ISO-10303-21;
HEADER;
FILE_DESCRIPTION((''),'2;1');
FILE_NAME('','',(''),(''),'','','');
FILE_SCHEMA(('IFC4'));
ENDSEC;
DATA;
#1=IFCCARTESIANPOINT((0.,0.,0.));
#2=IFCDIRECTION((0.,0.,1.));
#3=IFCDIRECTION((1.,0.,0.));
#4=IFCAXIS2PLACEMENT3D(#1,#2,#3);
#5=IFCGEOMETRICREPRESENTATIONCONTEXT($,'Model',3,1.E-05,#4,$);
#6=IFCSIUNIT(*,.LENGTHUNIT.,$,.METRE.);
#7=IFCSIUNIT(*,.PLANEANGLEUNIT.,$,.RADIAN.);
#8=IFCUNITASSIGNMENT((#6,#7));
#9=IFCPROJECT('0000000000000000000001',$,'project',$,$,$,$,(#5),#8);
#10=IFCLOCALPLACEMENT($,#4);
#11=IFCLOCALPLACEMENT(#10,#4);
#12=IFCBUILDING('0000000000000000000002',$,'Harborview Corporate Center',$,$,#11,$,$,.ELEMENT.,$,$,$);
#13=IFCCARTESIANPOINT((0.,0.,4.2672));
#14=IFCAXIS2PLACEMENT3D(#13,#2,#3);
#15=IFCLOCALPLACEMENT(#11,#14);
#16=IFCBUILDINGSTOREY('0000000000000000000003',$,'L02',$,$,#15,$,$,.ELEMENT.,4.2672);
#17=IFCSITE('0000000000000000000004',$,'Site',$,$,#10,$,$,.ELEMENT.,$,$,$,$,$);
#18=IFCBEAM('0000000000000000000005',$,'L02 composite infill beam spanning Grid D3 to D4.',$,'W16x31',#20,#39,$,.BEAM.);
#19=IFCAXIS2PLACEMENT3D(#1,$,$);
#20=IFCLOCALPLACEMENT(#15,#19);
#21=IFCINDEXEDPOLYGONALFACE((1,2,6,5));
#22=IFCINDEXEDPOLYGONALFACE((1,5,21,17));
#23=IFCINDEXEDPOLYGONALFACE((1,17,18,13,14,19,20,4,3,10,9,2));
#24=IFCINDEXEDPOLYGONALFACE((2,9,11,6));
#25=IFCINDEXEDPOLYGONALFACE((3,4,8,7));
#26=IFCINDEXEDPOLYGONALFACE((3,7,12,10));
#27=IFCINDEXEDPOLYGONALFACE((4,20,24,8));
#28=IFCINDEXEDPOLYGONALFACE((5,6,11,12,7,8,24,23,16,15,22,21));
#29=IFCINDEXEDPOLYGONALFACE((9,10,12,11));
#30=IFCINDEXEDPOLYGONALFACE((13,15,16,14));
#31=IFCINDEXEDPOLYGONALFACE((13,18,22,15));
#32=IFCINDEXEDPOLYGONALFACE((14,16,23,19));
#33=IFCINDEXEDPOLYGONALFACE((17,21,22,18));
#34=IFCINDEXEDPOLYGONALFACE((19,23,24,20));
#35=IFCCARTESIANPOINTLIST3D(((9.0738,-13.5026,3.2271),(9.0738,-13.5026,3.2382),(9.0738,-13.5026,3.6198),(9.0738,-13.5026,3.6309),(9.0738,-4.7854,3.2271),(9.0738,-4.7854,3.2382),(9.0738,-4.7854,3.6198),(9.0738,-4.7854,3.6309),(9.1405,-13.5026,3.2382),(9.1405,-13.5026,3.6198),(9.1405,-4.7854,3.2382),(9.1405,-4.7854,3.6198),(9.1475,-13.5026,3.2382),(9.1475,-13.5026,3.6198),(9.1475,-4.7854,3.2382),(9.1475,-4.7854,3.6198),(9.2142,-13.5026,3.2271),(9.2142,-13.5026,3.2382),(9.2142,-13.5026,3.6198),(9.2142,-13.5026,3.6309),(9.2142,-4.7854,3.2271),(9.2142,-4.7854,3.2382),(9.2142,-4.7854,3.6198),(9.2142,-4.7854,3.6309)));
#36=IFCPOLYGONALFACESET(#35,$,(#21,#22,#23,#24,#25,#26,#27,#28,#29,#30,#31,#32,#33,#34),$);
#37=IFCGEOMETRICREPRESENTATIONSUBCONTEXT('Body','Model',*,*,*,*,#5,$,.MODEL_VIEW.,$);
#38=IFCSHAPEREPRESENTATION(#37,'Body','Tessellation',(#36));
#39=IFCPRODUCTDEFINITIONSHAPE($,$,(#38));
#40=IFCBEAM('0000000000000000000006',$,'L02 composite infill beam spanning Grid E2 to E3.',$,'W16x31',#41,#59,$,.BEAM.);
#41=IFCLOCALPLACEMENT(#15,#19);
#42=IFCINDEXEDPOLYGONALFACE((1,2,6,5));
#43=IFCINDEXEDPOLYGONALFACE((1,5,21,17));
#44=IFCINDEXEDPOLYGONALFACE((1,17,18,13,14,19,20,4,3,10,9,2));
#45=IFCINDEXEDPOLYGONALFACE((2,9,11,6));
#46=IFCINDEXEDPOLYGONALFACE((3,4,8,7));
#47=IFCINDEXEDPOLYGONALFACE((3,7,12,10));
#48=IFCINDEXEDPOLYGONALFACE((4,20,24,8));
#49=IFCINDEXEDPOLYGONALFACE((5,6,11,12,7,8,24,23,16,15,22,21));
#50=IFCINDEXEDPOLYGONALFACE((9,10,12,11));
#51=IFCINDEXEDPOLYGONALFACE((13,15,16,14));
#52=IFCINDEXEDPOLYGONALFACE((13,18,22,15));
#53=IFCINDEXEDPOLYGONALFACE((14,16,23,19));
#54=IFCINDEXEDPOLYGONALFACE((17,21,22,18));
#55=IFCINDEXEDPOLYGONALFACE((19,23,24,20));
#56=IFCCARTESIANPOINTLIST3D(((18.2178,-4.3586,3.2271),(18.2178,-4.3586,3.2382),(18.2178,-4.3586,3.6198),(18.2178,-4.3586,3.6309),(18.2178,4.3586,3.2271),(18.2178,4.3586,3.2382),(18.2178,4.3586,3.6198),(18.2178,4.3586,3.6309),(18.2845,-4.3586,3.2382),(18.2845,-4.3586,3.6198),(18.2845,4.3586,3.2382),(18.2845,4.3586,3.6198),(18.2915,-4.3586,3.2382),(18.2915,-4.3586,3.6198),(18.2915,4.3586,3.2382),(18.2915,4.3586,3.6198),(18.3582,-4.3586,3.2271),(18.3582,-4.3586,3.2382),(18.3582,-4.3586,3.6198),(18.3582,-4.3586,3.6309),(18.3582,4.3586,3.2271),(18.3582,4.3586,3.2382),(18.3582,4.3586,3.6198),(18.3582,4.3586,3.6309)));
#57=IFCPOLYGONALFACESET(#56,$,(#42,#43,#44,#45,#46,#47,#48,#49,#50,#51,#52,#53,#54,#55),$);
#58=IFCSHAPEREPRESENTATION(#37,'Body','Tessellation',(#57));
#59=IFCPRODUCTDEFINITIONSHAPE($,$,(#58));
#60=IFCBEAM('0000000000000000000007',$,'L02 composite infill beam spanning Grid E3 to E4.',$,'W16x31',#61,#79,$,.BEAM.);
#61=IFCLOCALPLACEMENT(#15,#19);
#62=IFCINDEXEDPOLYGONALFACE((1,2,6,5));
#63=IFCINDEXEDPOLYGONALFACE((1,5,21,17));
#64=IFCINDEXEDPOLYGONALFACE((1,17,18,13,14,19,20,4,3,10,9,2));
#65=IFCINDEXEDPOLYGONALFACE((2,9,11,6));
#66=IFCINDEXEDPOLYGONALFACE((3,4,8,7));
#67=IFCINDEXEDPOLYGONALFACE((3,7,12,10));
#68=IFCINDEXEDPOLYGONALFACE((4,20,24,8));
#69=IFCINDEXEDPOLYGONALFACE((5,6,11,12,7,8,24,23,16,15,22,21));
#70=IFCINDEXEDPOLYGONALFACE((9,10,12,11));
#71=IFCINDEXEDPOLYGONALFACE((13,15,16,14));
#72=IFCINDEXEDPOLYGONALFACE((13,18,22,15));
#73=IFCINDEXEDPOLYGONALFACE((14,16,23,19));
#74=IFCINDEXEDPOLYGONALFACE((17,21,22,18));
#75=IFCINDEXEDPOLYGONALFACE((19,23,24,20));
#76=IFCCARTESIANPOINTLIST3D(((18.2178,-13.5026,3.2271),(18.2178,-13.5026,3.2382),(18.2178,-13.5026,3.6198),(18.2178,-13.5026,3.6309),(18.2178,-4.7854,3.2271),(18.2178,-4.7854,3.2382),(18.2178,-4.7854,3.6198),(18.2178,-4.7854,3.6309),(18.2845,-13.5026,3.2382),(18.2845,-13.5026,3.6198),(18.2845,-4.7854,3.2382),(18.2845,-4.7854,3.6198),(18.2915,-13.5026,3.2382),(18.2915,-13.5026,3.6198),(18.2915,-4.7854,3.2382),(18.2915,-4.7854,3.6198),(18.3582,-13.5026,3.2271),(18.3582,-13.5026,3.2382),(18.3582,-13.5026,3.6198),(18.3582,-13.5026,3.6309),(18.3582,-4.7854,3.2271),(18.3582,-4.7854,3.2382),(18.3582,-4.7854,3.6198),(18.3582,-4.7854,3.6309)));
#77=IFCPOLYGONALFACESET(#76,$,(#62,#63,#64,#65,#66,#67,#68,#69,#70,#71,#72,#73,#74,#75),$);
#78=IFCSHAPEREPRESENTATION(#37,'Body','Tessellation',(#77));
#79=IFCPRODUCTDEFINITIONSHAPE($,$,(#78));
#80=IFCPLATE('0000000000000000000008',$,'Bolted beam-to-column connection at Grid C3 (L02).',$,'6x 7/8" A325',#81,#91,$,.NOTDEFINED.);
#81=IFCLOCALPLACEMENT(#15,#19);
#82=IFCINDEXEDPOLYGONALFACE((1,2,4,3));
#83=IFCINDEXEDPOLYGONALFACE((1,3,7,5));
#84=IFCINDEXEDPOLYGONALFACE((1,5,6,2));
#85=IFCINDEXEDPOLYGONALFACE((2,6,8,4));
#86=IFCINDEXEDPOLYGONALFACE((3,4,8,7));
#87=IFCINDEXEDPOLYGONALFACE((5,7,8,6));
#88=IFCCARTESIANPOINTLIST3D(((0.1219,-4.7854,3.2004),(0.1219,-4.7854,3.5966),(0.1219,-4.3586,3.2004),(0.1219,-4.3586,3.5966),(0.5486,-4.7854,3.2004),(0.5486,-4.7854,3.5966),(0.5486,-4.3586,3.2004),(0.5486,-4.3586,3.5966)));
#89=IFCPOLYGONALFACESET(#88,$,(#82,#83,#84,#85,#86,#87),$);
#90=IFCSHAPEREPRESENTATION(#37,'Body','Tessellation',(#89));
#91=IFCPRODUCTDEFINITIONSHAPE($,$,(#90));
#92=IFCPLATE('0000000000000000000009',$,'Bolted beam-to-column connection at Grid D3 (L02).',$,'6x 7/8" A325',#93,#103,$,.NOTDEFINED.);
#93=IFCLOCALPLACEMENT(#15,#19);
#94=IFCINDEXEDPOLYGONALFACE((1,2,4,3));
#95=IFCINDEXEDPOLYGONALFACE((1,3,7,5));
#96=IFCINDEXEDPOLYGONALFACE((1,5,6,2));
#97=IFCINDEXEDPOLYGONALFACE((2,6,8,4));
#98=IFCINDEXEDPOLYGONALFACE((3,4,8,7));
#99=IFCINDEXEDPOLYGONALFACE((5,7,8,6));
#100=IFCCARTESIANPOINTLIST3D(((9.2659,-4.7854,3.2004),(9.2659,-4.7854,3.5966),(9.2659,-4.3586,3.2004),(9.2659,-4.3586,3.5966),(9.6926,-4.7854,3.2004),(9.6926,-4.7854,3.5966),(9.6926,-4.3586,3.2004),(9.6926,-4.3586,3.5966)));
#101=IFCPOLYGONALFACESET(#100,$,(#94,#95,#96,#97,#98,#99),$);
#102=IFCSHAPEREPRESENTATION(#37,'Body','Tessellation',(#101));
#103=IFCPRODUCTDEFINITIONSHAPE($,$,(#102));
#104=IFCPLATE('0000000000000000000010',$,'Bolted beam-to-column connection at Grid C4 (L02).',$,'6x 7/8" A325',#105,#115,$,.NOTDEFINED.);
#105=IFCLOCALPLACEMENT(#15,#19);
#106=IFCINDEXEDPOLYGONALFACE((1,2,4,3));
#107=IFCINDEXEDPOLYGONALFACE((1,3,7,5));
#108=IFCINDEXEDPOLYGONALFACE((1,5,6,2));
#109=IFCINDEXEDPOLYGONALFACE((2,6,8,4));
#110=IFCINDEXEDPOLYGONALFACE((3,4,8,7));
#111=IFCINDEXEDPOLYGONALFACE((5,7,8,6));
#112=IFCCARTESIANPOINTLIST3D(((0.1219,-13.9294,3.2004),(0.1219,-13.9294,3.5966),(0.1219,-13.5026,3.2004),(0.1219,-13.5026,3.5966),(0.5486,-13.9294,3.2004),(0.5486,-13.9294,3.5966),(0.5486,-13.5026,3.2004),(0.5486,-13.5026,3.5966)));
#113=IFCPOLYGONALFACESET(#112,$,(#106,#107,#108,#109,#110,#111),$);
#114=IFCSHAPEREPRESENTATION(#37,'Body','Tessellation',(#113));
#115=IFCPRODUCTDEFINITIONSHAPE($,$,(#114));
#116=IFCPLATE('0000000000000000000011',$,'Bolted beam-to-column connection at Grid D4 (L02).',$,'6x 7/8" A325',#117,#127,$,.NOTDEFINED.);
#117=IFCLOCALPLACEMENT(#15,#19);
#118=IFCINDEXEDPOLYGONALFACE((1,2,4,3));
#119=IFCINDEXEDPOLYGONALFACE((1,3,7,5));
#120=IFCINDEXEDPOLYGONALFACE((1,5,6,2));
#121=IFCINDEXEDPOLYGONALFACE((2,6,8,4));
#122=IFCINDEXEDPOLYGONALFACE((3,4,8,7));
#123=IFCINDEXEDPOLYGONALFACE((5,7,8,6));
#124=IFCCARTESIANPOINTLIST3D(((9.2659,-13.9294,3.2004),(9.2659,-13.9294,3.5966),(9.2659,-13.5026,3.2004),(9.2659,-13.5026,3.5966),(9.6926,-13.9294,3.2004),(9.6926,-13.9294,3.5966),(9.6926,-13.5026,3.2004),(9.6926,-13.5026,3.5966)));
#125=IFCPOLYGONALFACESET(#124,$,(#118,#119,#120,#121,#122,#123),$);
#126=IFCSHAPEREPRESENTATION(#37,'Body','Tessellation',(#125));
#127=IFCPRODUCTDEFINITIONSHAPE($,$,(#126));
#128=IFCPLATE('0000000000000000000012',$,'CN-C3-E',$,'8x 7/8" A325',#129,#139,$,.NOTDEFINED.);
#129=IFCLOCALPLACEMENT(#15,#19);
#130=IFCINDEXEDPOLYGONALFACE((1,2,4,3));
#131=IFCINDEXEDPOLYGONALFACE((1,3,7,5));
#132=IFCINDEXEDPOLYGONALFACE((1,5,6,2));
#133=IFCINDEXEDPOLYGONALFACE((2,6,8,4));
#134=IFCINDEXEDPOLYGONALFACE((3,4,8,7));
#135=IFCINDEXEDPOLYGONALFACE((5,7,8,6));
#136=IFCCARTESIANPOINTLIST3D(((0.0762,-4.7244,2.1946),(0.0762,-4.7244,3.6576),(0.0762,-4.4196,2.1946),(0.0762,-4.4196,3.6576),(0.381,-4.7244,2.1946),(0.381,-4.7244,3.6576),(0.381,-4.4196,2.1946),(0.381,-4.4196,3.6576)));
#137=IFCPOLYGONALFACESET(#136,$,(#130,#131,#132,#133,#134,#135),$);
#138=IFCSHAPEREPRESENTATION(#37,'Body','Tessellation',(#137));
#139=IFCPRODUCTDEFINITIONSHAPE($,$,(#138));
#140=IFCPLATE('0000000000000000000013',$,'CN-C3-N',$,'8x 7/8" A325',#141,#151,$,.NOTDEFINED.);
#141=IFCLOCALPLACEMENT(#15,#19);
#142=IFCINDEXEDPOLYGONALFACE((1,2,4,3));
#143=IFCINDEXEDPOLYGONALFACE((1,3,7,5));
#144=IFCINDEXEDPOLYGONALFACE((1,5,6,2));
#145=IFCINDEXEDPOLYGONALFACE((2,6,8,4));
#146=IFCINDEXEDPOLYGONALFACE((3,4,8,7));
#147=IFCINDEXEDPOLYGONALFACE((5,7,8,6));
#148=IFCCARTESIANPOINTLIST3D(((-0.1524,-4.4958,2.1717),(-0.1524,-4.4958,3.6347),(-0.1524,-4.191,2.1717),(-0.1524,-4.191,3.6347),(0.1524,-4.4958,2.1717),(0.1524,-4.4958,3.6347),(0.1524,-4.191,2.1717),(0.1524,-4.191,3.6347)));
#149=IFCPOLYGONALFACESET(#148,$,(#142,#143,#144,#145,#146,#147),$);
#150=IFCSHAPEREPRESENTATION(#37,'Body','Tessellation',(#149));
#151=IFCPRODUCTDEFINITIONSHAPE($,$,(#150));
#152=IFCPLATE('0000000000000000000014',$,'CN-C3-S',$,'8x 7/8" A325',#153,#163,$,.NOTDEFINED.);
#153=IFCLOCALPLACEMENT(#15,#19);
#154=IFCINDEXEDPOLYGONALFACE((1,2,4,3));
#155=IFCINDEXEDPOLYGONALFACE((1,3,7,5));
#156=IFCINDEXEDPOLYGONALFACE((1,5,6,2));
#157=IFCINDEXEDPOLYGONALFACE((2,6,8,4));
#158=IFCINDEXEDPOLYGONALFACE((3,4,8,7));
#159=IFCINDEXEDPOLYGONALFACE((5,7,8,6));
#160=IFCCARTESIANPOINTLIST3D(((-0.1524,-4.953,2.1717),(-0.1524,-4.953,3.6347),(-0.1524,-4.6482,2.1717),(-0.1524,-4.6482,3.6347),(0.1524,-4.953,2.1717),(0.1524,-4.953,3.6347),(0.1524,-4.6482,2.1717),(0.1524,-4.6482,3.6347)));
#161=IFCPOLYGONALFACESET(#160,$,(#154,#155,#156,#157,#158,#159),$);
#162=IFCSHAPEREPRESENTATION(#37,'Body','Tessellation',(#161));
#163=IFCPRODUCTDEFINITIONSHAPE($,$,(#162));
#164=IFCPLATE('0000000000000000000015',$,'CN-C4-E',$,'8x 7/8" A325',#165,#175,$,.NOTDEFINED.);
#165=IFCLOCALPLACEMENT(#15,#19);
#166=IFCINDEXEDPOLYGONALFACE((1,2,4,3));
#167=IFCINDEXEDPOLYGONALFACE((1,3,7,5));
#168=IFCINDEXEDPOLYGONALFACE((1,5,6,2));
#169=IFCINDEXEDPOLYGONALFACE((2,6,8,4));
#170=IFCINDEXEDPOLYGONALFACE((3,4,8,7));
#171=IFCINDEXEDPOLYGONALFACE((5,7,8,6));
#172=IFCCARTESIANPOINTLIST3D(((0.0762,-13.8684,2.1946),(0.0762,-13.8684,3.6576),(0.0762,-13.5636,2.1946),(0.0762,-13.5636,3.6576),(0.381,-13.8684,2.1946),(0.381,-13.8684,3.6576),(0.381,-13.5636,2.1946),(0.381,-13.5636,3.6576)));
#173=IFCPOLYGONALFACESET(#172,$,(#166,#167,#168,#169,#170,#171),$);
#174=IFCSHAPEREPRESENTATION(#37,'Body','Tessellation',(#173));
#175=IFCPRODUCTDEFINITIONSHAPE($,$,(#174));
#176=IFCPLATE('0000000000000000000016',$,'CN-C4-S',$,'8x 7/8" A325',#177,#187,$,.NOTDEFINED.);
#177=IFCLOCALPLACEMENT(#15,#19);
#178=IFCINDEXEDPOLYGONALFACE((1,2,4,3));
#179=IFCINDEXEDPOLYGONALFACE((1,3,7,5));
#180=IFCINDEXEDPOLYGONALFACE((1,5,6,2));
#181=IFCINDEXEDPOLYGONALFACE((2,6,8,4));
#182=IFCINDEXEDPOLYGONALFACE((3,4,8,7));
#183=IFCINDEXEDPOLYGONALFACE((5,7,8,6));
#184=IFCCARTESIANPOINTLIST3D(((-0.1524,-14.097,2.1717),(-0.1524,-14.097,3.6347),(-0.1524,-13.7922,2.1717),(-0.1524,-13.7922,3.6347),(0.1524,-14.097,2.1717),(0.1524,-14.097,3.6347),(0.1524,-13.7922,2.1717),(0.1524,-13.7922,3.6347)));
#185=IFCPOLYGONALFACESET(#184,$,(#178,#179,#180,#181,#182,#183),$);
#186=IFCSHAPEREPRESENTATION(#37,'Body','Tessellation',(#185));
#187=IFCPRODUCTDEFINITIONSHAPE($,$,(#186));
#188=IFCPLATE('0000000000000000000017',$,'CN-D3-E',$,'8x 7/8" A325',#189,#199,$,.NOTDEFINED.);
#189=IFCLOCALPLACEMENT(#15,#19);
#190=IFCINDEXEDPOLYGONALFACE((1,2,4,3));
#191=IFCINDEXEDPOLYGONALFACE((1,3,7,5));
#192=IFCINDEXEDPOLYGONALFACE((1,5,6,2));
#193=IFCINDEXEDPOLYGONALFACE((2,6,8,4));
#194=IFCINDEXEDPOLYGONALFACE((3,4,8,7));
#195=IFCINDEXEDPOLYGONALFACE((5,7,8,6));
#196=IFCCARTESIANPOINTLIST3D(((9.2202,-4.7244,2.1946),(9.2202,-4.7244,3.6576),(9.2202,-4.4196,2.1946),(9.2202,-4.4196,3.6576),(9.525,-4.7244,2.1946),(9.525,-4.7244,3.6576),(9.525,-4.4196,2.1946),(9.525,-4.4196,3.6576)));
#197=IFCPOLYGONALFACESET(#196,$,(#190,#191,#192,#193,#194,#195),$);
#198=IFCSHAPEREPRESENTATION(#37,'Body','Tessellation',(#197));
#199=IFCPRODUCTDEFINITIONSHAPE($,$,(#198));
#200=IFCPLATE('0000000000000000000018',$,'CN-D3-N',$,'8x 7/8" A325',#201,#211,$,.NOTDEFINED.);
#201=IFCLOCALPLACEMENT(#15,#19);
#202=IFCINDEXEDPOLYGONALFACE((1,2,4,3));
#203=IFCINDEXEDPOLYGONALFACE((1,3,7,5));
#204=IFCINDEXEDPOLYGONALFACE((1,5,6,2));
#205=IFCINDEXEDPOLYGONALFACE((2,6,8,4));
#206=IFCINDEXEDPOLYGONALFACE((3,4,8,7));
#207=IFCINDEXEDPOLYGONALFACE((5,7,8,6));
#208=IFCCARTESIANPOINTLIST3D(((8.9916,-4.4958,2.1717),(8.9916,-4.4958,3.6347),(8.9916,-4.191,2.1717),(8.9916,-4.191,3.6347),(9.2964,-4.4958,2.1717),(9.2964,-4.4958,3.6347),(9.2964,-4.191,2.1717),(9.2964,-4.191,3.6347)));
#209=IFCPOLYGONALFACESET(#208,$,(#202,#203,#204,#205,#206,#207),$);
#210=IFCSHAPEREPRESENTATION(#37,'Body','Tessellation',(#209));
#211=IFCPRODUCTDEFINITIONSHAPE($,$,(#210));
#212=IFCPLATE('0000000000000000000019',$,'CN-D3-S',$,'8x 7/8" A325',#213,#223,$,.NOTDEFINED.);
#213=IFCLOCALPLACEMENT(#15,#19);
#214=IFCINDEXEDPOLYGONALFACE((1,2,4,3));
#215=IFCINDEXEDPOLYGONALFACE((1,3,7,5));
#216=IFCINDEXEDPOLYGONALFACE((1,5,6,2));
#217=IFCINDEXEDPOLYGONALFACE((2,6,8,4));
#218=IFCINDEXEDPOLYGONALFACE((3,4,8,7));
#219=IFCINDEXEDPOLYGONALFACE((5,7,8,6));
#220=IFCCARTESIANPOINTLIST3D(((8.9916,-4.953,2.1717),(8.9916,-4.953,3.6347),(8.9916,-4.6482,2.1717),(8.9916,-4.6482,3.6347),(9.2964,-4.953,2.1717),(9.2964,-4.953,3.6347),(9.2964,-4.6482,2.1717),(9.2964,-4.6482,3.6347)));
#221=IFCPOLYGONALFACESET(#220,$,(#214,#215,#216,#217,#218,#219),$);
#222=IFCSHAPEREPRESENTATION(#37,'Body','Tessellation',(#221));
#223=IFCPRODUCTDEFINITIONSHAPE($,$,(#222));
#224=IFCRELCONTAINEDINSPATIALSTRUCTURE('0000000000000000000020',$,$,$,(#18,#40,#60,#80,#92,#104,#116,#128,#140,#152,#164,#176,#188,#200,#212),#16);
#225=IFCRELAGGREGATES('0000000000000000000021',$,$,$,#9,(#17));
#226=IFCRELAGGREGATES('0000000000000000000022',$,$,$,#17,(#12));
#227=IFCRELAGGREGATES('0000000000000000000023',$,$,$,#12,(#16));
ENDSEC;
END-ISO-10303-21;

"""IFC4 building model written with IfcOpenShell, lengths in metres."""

from ifc_helpers import new_model, si_unit, frame, origin_with_axes, place, context, subcontext, project, spatial, rectangle, i_section, extrude, element, save


model = new_model("IFC4")

# Units and contexts
model_context = context("Model", 3, precision=1e-05, world=origin_with_axes())
body_context = subcontext(model_context, "Body", "Model", "MODEL_VIEW")
ifc_project = project(units=[si_unit("LENGTHUNIT", "METRE"), si_unit("PLANEANGLEUNIT", "RADIAN")], contexts=[model_context])

# Site, building, storey
site_placement = place(None, origin_with_axes())
site = spatial("IfcSite", under=ifc_project, at=site_placement, Name="Site", CompositionType="ELEMENT")
building_placement = place(site_placement, origin_with_axes())
building = spatial("IfcBuilding", under=site, at=building_placement, Name="Harborview Corporate Center", CompositionType="ELEMENT")
storey_placement = place(building_placement, frame((0.0, 0.0, 4.2672), z_axis=(0.0, 0.0, 1.0), x_axis=(1.0, 0.0, 0.0)))
storey = spatial("IfcBuildingStorey", under=building, at=storey_placement, Name="L02", CompositionType="ELEMENT", Elevation=4.2672)

# Beams
beam_1_placement = place(storey_placement, frame((9.144, -13.5026, 3.429), z_axis=(0.0, 1.0, 0.0), x_axis=(-1.0, 0.0, 0.0)))
element("IfcBeam", 1, at=beam_1_placement, inside=storey, Name="L02 composite infill beam spanning Grid D3 to D4.", ObjectType="W16x31", PredefinedType="BEAM", context=body_context, shape_type="SweptSolid", body=[
    extrude(i_section(OverallWidth=0.1405, OverallDepth=0.4039, WebThickness=0.007, FlangeThickness=0.0112), origin_with_axes(), (0.0, 0.0, 1.0), 8.7173),
])
beam_2_placement = place(storey_placement, frame((18.288, -4.3586, 3.429), z_axis=(0.0, 1.0, 0.0), x_axis=(-1.0, 0.0, 0.0)))
element("IfcBeam", 2, at=beam_2_placement, inside=storey, Name="L02 composite infill beam spanning Grid E2 to E3.", ObjectType="W16x31", PredefinedType="BEAM", context=body_context, shape_type="SweptSolid", body=[
    extrude(i_section(OverallWidth=0.1405, OverallDepth=0.4039, WebThickness=0.007, FlangeThickness=0.0112), origin_with_axes(), (0.0, 0.0, 1.0), 8.7173),
])
beam_3_placement = place(storey_placement, frame((18.288, -13.5026, 3.429), z_axis=(0.0, 1.0, 0.0), x_axis=(-1.0, 0.0, 0.0)))
element("IfcBeam", 3, at=beam_3_placement, inside=storey, Name="L02 composite infill beam spanning Grid E3 to E4.", ObjectType="W16x31", PredefinedType="BEAM", context=body_context, shape_type="SweptSolid", body=[
    extrude(i_section(OverallWidth=0.1405, OverallDepth=0.4039, WebThickness=0.007, FlangeThickness=0.0112), origin_with_axes(), (0.0, 0.0, 1.0), 8.7173),
])

# Plates
plate_1_placement = place(storey_placement, frame((0.3353, -4.572, 3.2004), z_axis=(0.0, 0.0, 1.0), x_axis=(1.0, 0.0, 0.0)))
element("IfcPlate", 4, at=plate_1_placement, inside=storey, Name="Bolted beam-to-column connection at Grid C3 (L02).", ObjectType="6x 7/8\" A325", PredefinedType="NOTDEFINED", context=body_context, shape_type="SweptSolid", body=[
    extrude(rectangle(XDim=0.4267, YDim=0.4267), origin_with_axes(), (0.0, 0.0, 1.0), 0.3962),
])
plate_2_placement = place(storey_placement, frame((9.4793, -4.572, 3.2004), z_axis=(0.0, 0.0, 1.0), x_axis=(1.0, 0.0, 0.0)))
element("IfcPlate", 5, at=plate_2_placement, inside=storey, Name="Bolted beam-to-column connection at Grid D3 (L02).", ObjectType="6x 7/8\" A325", PredefinedType="NOTDEFINED", context=body_context, shape_type="SweptSolid", body=[
    extrude(rectangle(XDim=0.4267, YDim=0.4267), origin_with_axes(), (0.0, 0.0, 1.0), 0.3962),
])
plate_3_placement = place(storey_placement, frame((0.3353, -13.716, 3.2004), z_axis=(0.0, 0.0, 1.0), x_axis=(1.0, 0.0, 0.0)))
element("IfcPlate", 6, at=plate_3_placement, inside=storey, Name="Bolted beam-to-column connection at Grid C4 (L02).", ObjectType="6x 7/8\" A325", PredefinedType="NOTDEFINED", context=body_context, shape_type="SweptSolid", body=[
    extrude(rectangle(XDim=0.4267, YDim=0.4267), origin_with_axes(), (0.0, 0.0, 1.0), 0.3962),
])
plate_4_placement = place(storey_placement, frame((9.4793, -13.716, 3.2004), z_axis=(0.0, 0.0, 1.0), x_axis=(1.0, 0.0, 0.0)))
element("IfcPlate", 7, at=plate_4_placement, inside=storey, Name="Bolted beam-to-column connection at Grid D4 (L02).", ObjectType="6x 7/8\" A325", PredefinedType="NOTDEFINED", context=body_context, shape_type="SweptSolid", body=[
    extrude(rectangle(XDim=0.4267, YDim=0.4267), origin_with_axes(), (0.0, 0.0, 1.0), 0.3962),
])
for number, where, z_axis, x_axis, name in (
    (8, (0.2286, -4.572, 2.1946), (0.0, 0.0, 1.0), (1.0, 0.0, 0.0), "CN-C3-E"),
    (9, (0.0, -4.3434, 2.1717), (0.0, 0.0, 1.0), (1.0, 0.0, 0.0), "CN-C3-N"),
    (10, (0.0, -4.8006, 2.1717), (0.0, 0.0, 1.0), (1.0, 0.0, 0.0), "CN-C3-S"),
    (11, (0.2286, -13.716, 2.1946), (0.0, 0.0, 1.0), (1.0, 0.0, 0.0), "CN-C4-E"),
    (12, (0.0, -13.9446, 2.1717), (0.0, 0.0, 1.0), (1.0, 0.0, 0.0), "CN-C4-S"),
):
    element("IfcPlate", number, at=place(storey_placement, frame(where, z_axis=z_axis, x_axis=x_axis)), inside=storey, Name=name, ObjectType="8x 7/8\" A325", PredefinedType="NOTDEFINED", context=body_context, shape_type="SweptSolid", body=[
        extrude(rectangle(XDim=0.3048, YDim=0.3048), origin_with_axes(), (0.0, 0.0, 1.0), 1.463),
    ])
for number, where, z_axis, x_axis, name in (
    (13, (9.3726, -4.572, 2.1946), (0.0, 0.0, 1.0), (1.0, 0.0, 0.0), "CN-D3-E"),
    (14, (9.144, -4.3434, 2.1717), (0.0, 0.0, 1.0), (1.0, 0.0, 0.0), "CN-D3-N"),
    (15, (9.144, -4.8006, 2.1717), (0.0, 0.0, 1.0), (1.0, 0.0, 0.0), "CN-D3-S"),
):
    element("IfcPlate", number, at=place(storey_placement, frame(where, z_axis=z_axis, x_axis=x_axis)), inside=storey, Name=name, ObjectType="8x 7/8\" A325", PredefinedType="NOTDEFINED", context=body_context, shape_type="SweptSolid", body=[
        extrude(rectangle(XDim=0.3048, YDim=0.3048), origin_with_axes(), (0.0, 0.0, 1.0), 1.463),
    ])

save(model, "model.ifc")
